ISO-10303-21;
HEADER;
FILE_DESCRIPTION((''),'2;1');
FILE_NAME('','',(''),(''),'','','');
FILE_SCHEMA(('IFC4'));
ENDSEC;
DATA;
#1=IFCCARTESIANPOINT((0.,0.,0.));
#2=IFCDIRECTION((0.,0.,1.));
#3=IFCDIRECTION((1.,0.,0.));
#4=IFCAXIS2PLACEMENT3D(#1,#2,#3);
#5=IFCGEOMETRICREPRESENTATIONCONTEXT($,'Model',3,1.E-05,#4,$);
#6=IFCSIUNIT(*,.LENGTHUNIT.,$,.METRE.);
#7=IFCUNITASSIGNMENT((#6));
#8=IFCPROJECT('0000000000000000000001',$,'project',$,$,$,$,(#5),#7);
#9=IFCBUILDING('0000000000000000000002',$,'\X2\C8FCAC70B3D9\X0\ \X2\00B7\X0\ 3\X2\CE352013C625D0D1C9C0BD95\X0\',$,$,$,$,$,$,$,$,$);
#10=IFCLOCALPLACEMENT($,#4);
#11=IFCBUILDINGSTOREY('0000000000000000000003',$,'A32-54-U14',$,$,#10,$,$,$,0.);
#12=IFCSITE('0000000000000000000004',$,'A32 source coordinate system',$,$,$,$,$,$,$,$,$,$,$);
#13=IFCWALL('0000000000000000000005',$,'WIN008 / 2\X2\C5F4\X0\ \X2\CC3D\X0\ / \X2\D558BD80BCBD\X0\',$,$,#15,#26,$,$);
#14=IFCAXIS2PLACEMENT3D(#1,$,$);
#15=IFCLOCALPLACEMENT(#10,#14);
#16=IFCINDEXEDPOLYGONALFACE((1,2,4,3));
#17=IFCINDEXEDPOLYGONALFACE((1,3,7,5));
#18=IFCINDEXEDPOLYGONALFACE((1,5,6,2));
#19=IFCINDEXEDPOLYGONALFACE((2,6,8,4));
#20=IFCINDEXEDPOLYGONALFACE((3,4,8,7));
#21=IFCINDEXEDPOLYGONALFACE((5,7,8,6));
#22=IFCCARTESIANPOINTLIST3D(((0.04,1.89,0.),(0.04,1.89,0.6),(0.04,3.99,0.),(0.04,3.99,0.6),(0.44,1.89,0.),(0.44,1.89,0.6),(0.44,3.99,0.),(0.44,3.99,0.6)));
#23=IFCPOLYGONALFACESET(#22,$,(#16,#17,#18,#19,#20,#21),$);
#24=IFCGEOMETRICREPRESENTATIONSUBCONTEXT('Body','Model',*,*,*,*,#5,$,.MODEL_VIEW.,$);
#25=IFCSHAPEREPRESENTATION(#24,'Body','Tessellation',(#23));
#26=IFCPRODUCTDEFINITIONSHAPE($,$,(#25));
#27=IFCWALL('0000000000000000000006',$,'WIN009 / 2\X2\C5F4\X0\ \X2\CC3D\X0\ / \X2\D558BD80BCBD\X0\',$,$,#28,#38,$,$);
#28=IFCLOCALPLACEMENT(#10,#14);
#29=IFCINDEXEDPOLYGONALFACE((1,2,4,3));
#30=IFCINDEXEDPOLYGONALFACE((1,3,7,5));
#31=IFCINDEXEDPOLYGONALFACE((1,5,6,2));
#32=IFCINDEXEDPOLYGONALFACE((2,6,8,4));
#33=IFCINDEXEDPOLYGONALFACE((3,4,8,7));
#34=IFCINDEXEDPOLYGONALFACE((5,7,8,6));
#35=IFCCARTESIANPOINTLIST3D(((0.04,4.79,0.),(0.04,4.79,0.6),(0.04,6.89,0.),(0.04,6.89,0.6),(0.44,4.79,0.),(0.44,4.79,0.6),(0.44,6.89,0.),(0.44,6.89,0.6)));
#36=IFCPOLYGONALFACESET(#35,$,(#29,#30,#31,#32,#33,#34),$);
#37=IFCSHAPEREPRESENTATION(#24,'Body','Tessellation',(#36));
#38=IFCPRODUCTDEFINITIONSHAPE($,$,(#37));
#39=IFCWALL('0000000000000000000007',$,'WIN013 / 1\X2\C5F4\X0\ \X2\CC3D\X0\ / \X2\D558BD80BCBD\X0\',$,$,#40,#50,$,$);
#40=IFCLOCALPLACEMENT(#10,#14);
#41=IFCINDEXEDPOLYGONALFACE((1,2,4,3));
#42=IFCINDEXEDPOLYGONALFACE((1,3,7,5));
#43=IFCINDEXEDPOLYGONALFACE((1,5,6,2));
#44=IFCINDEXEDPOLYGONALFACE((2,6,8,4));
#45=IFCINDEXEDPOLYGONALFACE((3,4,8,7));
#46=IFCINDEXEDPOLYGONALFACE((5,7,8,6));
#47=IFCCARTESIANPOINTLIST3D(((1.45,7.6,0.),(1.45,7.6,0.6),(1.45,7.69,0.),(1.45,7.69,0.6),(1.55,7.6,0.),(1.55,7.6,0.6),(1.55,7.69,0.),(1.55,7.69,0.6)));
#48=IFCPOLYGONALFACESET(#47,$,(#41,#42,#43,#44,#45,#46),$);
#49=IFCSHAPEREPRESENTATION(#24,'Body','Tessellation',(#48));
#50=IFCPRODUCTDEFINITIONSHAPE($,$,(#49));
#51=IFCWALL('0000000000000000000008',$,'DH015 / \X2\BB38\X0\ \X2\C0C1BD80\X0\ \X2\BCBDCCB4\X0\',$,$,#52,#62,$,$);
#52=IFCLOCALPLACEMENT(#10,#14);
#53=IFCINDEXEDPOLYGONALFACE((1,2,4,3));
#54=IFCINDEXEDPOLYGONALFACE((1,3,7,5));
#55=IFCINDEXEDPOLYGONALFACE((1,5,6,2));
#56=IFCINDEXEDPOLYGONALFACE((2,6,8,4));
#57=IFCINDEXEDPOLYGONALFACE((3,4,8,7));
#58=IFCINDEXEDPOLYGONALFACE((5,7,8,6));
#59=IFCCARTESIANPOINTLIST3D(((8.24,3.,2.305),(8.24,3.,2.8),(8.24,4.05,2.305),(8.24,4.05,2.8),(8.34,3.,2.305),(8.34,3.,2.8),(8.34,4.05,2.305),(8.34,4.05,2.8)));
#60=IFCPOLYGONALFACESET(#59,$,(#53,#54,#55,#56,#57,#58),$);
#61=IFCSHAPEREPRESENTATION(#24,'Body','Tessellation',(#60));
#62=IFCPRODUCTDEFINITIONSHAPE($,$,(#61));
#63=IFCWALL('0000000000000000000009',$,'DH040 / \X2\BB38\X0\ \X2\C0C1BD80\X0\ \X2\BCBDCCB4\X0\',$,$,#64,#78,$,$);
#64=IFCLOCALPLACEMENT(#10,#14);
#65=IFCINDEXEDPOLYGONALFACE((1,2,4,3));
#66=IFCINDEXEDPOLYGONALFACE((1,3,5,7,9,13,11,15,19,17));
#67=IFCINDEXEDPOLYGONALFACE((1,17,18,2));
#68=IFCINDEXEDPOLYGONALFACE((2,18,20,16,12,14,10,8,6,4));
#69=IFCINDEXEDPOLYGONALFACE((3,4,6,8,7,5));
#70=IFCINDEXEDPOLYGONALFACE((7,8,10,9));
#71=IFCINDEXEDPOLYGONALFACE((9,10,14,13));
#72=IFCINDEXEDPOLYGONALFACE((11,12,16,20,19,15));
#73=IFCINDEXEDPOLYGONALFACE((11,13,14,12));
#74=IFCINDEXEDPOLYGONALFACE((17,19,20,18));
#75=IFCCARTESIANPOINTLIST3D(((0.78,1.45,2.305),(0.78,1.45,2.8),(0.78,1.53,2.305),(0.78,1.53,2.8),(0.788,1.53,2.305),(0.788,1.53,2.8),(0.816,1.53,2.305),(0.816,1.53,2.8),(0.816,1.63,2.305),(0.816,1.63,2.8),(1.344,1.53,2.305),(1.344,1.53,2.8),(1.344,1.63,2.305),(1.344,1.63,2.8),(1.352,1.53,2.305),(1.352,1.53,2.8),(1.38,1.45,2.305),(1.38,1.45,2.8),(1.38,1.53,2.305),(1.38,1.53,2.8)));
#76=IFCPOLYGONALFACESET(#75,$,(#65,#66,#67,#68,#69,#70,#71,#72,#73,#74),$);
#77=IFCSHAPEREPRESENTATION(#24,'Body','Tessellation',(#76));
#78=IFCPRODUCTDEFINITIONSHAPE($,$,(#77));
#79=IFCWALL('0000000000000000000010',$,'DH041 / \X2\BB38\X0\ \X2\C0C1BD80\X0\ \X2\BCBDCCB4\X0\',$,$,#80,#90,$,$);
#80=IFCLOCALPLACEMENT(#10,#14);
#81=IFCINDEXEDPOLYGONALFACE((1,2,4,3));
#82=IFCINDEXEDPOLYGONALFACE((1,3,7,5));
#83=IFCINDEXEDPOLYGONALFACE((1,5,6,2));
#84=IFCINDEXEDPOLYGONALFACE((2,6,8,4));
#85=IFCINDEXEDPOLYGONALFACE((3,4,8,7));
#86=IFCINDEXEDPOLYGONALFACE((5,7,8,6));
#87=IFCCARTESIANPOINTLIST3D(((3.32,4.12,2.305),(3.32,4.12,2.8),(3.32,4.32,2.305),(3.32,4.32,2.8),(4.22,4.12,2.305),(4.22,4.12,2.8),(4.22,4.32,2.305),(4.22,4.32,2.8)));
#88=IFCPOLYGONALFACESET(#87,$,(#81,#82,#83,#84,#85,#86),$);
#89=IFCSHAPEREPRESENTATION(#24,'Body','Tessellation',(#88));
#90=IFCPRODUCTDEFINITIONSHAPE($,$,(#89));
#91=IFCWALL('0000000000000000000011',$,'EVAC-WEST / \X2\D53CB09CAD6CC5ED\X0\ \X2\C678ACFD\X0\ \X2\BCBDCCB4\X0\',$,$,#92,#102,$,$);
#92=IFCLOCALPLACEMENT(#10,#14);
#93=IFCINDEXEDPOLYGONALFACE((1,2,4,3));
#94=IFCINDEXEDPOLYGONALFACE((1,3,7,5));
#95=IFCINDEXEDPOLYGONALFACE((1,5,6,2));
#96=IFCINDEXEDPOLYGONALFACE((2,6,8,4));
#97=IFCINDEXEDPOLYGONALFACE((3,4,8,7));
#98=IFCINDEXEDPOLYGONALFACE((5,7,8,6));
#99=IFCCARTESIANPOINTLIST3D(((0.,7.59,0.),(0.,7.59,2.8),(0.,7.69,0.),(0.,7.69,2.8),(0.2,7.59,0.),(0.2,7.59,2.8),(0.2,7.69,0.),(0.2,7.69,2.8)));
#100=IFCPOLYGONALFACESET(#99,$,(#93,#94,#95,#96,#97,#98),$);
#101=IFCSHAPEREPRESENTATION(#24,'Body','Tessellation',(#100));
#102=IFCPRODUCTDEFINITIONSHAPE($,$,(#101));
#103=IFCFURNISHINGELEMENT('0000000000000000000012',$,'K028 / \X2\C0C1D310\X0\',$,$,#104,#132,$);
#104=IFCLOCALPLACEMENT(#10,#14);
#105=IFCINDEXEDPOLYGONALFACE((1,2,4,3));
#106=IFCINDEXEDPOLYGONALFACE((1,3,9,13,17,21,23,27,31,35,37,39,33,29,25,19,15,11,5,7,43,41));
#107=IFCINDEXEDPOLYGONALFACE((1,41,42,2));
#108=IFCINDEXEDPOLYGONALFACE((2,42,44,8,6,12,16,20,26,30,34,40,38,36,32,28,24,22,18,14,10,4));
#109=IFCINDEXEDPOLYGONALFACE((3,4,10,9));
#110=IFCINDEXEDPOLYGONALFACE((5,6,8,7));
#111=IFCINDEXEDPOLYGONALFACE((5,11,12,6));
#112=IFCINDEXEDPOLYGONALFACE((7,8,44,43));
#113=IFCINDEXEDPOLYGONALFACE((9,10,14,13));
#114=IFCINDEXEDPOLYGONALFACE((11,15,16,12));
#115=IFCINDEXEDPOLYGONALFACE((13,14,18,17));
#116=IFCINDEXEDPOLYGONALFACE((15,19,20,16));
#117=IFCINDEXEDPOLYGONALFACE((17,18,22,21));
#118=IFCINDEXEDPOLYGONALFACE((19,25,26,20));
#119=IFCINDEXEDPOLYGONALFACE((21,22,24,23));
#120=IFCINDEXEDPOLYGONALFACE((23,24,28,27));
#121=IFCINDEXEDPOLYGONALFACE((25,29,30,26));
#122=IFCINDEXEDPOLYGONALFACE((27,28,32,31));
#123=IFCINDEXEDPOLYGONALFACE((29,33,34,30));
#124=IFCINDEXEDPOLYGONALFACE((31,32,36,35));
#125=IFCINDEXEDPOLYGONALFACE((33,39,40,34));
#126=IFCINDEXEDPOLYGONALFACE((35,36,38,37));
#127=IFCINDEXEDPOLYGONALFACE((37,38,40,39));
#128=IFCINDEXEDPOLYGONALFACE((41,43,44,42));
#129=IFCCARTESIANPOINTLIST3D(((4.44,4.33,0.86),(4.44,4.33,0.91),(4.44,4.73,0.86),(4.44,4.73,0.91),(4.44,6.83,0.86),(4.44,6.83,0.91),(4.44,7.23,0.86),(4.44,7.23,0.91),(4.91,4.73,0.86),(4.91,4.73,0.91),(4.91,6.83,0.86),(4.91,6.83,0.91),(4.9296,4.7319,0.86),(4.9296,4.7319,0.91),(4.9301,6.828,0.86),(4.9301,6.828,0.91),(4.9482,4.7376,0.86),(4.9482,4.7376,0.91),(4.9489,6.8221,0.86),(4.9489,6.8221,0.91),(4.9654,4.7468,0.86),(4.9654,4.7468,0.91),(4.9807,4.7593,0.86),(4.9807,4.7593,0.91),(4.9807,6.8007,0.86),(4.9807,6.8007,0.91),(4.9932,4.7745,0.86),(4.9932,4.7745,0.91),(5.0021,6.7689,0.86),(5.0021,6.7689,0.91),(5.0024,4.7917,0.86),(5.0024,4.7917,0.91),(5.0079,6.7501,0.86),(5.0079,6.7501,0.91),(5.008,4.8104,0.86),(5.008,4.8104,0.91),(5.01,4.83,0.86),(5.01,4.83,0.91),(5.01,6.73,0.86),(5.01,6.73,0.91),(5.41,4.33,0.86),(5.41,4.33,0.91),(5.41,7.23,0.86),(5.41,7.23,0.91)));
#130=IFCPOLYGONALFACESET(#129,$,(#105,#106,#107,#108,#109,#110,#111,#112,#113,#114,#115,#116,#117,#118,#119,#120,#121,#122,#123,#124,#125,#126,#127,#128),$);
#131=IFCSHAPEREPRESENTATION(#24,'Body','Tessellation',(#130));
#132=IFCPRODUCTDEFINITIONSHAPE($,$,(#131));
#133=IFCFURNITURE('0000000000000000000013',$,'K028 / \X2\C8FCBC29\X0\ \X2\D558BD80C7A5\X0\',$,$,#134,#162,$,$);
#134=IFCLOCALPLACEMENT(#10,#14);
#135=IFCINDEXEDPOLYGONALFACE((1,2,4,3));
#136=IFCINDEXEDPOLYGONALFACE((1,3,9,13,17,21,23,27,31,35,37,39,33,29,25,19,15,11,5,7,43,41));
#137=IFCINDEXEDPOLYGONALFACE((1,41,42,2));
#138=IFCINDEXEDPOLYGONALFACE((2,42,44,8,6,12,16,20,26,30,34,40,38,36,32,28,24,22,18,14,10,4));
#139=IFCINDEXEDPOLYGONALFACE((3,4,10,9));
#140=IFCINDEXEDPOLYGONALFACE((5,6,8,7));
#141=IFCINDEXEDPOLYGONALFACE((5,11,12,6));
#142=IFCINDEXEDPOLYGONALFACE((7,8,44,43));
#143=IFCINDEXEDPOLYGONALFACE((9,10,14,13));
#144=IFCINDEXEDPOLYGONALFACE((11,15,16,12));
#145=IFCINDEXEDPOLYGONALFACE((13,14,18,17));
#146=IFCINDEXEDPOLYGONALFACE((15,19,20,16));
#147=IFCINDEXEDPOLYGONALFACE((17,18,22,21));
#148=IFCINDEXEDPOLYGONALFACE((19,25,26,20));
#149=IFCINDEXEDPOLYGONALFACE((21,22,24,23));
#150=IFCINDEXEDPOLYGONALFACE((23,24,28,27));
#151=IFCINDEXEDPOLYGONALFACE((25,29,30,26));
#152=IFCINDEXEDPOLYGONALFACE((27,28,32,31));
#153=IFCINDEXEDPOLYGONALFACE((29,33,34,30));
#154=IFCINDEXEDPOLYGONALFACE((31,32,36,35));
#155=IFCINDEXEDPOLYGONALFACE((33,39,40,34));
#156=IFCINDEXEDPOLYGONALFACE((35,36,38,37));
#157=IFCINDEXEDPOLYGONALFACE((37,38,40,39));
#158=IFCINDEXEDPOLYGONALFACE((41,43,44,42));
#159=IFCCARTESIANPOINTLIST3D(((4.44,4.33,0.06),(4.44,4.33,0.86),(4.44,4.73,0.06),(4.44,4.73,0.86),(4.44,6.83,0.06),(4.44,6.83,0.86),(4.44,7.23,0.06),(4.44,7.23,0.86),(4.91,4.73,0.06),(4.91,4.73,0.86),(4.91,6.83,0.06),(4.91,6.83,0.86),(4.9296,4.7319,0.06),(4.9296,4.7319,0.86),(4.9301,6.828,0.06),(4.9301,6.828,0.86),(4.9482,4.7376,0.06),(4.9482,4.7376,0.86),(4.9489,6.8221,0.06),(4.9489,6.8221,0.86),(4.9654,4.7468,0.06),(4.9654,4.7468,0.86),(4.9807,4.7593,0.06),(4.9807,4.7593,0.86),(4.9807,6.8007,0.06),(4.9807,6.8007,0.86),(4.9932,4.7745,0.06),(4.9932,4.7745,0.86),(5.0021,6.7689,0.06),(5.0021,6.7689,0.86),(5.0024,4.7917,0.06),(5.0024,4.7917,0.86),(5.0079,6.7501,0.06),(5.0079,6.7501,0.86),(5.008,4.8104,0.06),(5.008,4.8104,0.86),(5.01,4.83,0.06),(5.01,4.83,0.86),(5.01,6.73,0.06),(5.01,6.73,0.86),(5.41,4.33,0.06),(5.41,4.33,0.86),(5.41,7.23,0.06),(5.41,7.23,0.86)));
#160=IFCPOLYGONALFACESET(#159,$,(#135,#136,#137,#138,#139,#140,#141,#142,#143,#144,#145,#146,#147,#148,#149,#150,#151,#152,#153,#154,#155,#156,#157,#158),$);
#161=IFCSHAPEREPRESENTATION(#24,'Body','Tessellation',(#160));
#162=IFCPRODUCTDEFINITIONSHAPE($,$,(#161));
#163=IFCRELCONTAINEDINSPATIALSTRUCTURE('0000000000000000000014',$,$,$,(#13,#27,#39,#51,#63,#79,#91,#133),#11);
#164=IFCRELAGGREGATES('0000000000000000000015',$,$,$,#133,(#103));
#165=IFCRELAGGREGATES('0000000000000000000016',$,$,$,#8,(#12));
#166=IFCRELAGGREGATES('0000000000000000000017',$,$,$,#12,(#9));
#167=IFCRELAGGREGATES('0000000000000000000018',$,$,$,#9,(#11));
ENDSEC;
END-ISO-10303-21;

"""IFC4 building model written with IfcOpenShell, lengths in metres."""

from ifc_helpers import new_model, si_unit, frame, origin, origin_with_axes, place, context, subcontext, project, spatial, polyline, outline, extrude, element, aggregate, save


model = new_model("IFC4")

# Units and contexts
model_context = context("Model", 3, precision=1e-05, world=origin_with_axes())
body_context = subcontext(model_context, "Body", "Model", "MODEL_VIEW")
ifc_project = project(units=[si_unit("LENGTHUNIT", "METRE")], contexts=[model_context])

# Site, building, storey
site = spatial("IfcSite", under=ifc_project, Name="A32 source coordinate system")
building = spatial("IfcBuilding", under=site, Name="주거동 · 3층–옥탑지붕")
storey_placement = place(None, origin_with_axes())
storey = spatial("IfcBuildingStorey", under=building, at=storey_placement, Name="A32-54-U14", Elevation=0.0)

# Walls
wall_1_placement = place(storey_placement, origin_with_axes())
element("IfcWall", 1, at=wall_1_placement, inside=storey, Name="WIN008 / 2열 창 / 하부벽", context=body_context, shape_type="SweptSolid", body=[
    extrude(outline(polyline([(0.44, 3.99), (0.44, 1.89), (0.04, 1.89), (0.04, 3.99), (0.44, 3.99)])), origin(), (0.0, 0.0, 1.0), 0.6),
])
wall_2_placement = place(storey_placement, origin_with_axes())
element("IfcWall", 2, at=wall_2_placement, inside=storey, Name="WIN009 / 2열 창 / 하부벽", context=body_context, shape_type="SweptSolid", body=[
    extrude(outline(polyline([(0.44, 6.89), (0.44, 4.79), (0.04, 4.79), (0.04, 6.89), (0.44, 6.89)])), origin(), (0.0, 0.0, 1.0), 0.6),
])
wall_3_placement = place(storey_placement, origin_with_axes())
element("IfcWall", 3, at=wall_3_placement, inside=storey, Name="WIN013 / 1열 창 / 하부벽", context=body_context, shape_type="SweptSolid", body=[
    extrude(outline(polyline([(1.55, 7.6), (1.45, 7.6), (1.45, 7.69), (1.55, 7.69), (1.55, 7.6)])), origin(), (0.0, 0.0, 1.0), 0.6),
])
wall_4_placement = place(storey_placement, origin_with_axes())
element("IfcWall", 4, at=wall_4_placement, inside=storey, Name="DH015 / 문 상부 벽체", context=body_context, shape_type="SweptSolid", body=[
    extrude(outline(polyline([(8.34, 3.0), (8.24, 3.0), (8.24, 4.05), (8.34, 4.05), (8.34, 3.0)])), frame((0.0, 0.0, 2.305)), (0.0, 0.0, 1.0), 0.495),
])
wall_5_placement = place(storey_placement, origin_with_axes())
element("IfcWall", 5, at=wall_5_placement, inside=storey, Name="DH040 / 문 상부 벽체", context=body_context, shape_type="SweptSolid", body=[
    extrude(outline(polyline([(0.816, 1.63), (1.344, 1.63), (1.344, 1.53), (1.352, 1.53), (1.38, 1.53), (1.38, 1.45), (0.78, 1.45), (0.78, 1.53), (0.788, 1.53), (0.816, 1.53), (0.816, 1.63)])), frame((0.0, 0.0, 2.305)), (0.0, 0.0, 1.0), 0.495),
])
wall_6_placement = place(storey_placement, origin_with_axes())
element("IfcWall", 6, at=wall_6_placement, inside=storey, Name="DH041 / 문 상부 벽체", context=body_context, shape_type="SweptSolid", body=[
    extrude(outline(polyline([(4.22, 4.12), (3.32, 4.12), (3.32, 4.32), (4.22, 4.32), (4.22, 4.12)])), frame((0.0, 0.0, 2.305)), (0.0, 0.0, 1.0), 0.495),
])
wall_7_placement = place(storey_placement, origin_with_axes())
element("IfcWall", 7, at=wall_7_placement, inside=storey, Name="EVAC-WEST / 피난구역 외곽 벽체", context=body_context, shape_type="SweptSolid", body=[
    extrude(outline(polyline([(0.2, 7.59), (0.0, 7.59), (0.0, 7.69), (0.2, 7.69), (0.2, 7.59)])), origin(), (0.0, 0.0, 1.0), 2.8),
])

# Furnishing element
furniture_1_placement = place(storey_placement, origin_with_axes())
furnishing_1_placement = place(furniture_1_placement, origin_with_axes())
furnishing_1 = element("IfcFurnishingElement", 8, at=furnishing_1_placement, Name="K028 / 상판", context=body_context, shape_type="SweptSolid", body=[
    extrude(outline(polyline([(5.41, 4.33), (4.44, 4.33), (4.44, 4.73), (4.91, 4.73), (4.9296, 4.7319), (4.9482, 4.7376), (4.9654, 4.7468), (4.9807, 4.7593), (4.9932, 4.7745), (5.0024, 4.7917), (5.008, 4.8104), (5.01, 4.83), (5.01, 6.73), (5.0079, 6.7501), (5.0021, 6.7689), (4.9807, 6.8007), (4.9489, 6.8221), (4.9301, 6.828), (4.91, 6.83), (4.44, 6.83), (4.44, 7.23), (5.41, 7.23), (5.41, 4.33)])), frame((0.0, 0.0, 0.86)), (0.0, 0.0, 1.0), 0.05),
])

# Furniture
furniture_1 = element("IfcFurniture", 9, at=furniture_1_placement, inside=storey, Name="K028 / 주방 하부장", context=body_context, shape_type="SweptSolid", body=[
    extrude(outline(polyline([(5.41, 7.23), (5.41, 4.33), (4.44, 4.33), (4.44, 4.73), (4.91, 4.73), (4.9296, 4.7319), (4.9482, 4.7376), (4.9654, 4.7468), (4.9807, 4.7593), (4.9932, 4.7745), (5.0024, 4.7917), (5.008, 4.8104), (5.01, 4.83), (5.01, 6.73), (5.0079, 6.7501), (5.0021, 6.7689), (4.9807, 6.8007), (4.9489, 6.8221), (4.9301, 6.828), (4.91, 6.83), (4.44, 6.83), (4.44, 7.23), (5.41, 7.23)])), frame((0.0, 0.0, 0.06)), (0.0, 0.0, 1.0), 0.8),
])
aggregate(furniture_1, [furnishing_1])

save(model, "model.ifc")
